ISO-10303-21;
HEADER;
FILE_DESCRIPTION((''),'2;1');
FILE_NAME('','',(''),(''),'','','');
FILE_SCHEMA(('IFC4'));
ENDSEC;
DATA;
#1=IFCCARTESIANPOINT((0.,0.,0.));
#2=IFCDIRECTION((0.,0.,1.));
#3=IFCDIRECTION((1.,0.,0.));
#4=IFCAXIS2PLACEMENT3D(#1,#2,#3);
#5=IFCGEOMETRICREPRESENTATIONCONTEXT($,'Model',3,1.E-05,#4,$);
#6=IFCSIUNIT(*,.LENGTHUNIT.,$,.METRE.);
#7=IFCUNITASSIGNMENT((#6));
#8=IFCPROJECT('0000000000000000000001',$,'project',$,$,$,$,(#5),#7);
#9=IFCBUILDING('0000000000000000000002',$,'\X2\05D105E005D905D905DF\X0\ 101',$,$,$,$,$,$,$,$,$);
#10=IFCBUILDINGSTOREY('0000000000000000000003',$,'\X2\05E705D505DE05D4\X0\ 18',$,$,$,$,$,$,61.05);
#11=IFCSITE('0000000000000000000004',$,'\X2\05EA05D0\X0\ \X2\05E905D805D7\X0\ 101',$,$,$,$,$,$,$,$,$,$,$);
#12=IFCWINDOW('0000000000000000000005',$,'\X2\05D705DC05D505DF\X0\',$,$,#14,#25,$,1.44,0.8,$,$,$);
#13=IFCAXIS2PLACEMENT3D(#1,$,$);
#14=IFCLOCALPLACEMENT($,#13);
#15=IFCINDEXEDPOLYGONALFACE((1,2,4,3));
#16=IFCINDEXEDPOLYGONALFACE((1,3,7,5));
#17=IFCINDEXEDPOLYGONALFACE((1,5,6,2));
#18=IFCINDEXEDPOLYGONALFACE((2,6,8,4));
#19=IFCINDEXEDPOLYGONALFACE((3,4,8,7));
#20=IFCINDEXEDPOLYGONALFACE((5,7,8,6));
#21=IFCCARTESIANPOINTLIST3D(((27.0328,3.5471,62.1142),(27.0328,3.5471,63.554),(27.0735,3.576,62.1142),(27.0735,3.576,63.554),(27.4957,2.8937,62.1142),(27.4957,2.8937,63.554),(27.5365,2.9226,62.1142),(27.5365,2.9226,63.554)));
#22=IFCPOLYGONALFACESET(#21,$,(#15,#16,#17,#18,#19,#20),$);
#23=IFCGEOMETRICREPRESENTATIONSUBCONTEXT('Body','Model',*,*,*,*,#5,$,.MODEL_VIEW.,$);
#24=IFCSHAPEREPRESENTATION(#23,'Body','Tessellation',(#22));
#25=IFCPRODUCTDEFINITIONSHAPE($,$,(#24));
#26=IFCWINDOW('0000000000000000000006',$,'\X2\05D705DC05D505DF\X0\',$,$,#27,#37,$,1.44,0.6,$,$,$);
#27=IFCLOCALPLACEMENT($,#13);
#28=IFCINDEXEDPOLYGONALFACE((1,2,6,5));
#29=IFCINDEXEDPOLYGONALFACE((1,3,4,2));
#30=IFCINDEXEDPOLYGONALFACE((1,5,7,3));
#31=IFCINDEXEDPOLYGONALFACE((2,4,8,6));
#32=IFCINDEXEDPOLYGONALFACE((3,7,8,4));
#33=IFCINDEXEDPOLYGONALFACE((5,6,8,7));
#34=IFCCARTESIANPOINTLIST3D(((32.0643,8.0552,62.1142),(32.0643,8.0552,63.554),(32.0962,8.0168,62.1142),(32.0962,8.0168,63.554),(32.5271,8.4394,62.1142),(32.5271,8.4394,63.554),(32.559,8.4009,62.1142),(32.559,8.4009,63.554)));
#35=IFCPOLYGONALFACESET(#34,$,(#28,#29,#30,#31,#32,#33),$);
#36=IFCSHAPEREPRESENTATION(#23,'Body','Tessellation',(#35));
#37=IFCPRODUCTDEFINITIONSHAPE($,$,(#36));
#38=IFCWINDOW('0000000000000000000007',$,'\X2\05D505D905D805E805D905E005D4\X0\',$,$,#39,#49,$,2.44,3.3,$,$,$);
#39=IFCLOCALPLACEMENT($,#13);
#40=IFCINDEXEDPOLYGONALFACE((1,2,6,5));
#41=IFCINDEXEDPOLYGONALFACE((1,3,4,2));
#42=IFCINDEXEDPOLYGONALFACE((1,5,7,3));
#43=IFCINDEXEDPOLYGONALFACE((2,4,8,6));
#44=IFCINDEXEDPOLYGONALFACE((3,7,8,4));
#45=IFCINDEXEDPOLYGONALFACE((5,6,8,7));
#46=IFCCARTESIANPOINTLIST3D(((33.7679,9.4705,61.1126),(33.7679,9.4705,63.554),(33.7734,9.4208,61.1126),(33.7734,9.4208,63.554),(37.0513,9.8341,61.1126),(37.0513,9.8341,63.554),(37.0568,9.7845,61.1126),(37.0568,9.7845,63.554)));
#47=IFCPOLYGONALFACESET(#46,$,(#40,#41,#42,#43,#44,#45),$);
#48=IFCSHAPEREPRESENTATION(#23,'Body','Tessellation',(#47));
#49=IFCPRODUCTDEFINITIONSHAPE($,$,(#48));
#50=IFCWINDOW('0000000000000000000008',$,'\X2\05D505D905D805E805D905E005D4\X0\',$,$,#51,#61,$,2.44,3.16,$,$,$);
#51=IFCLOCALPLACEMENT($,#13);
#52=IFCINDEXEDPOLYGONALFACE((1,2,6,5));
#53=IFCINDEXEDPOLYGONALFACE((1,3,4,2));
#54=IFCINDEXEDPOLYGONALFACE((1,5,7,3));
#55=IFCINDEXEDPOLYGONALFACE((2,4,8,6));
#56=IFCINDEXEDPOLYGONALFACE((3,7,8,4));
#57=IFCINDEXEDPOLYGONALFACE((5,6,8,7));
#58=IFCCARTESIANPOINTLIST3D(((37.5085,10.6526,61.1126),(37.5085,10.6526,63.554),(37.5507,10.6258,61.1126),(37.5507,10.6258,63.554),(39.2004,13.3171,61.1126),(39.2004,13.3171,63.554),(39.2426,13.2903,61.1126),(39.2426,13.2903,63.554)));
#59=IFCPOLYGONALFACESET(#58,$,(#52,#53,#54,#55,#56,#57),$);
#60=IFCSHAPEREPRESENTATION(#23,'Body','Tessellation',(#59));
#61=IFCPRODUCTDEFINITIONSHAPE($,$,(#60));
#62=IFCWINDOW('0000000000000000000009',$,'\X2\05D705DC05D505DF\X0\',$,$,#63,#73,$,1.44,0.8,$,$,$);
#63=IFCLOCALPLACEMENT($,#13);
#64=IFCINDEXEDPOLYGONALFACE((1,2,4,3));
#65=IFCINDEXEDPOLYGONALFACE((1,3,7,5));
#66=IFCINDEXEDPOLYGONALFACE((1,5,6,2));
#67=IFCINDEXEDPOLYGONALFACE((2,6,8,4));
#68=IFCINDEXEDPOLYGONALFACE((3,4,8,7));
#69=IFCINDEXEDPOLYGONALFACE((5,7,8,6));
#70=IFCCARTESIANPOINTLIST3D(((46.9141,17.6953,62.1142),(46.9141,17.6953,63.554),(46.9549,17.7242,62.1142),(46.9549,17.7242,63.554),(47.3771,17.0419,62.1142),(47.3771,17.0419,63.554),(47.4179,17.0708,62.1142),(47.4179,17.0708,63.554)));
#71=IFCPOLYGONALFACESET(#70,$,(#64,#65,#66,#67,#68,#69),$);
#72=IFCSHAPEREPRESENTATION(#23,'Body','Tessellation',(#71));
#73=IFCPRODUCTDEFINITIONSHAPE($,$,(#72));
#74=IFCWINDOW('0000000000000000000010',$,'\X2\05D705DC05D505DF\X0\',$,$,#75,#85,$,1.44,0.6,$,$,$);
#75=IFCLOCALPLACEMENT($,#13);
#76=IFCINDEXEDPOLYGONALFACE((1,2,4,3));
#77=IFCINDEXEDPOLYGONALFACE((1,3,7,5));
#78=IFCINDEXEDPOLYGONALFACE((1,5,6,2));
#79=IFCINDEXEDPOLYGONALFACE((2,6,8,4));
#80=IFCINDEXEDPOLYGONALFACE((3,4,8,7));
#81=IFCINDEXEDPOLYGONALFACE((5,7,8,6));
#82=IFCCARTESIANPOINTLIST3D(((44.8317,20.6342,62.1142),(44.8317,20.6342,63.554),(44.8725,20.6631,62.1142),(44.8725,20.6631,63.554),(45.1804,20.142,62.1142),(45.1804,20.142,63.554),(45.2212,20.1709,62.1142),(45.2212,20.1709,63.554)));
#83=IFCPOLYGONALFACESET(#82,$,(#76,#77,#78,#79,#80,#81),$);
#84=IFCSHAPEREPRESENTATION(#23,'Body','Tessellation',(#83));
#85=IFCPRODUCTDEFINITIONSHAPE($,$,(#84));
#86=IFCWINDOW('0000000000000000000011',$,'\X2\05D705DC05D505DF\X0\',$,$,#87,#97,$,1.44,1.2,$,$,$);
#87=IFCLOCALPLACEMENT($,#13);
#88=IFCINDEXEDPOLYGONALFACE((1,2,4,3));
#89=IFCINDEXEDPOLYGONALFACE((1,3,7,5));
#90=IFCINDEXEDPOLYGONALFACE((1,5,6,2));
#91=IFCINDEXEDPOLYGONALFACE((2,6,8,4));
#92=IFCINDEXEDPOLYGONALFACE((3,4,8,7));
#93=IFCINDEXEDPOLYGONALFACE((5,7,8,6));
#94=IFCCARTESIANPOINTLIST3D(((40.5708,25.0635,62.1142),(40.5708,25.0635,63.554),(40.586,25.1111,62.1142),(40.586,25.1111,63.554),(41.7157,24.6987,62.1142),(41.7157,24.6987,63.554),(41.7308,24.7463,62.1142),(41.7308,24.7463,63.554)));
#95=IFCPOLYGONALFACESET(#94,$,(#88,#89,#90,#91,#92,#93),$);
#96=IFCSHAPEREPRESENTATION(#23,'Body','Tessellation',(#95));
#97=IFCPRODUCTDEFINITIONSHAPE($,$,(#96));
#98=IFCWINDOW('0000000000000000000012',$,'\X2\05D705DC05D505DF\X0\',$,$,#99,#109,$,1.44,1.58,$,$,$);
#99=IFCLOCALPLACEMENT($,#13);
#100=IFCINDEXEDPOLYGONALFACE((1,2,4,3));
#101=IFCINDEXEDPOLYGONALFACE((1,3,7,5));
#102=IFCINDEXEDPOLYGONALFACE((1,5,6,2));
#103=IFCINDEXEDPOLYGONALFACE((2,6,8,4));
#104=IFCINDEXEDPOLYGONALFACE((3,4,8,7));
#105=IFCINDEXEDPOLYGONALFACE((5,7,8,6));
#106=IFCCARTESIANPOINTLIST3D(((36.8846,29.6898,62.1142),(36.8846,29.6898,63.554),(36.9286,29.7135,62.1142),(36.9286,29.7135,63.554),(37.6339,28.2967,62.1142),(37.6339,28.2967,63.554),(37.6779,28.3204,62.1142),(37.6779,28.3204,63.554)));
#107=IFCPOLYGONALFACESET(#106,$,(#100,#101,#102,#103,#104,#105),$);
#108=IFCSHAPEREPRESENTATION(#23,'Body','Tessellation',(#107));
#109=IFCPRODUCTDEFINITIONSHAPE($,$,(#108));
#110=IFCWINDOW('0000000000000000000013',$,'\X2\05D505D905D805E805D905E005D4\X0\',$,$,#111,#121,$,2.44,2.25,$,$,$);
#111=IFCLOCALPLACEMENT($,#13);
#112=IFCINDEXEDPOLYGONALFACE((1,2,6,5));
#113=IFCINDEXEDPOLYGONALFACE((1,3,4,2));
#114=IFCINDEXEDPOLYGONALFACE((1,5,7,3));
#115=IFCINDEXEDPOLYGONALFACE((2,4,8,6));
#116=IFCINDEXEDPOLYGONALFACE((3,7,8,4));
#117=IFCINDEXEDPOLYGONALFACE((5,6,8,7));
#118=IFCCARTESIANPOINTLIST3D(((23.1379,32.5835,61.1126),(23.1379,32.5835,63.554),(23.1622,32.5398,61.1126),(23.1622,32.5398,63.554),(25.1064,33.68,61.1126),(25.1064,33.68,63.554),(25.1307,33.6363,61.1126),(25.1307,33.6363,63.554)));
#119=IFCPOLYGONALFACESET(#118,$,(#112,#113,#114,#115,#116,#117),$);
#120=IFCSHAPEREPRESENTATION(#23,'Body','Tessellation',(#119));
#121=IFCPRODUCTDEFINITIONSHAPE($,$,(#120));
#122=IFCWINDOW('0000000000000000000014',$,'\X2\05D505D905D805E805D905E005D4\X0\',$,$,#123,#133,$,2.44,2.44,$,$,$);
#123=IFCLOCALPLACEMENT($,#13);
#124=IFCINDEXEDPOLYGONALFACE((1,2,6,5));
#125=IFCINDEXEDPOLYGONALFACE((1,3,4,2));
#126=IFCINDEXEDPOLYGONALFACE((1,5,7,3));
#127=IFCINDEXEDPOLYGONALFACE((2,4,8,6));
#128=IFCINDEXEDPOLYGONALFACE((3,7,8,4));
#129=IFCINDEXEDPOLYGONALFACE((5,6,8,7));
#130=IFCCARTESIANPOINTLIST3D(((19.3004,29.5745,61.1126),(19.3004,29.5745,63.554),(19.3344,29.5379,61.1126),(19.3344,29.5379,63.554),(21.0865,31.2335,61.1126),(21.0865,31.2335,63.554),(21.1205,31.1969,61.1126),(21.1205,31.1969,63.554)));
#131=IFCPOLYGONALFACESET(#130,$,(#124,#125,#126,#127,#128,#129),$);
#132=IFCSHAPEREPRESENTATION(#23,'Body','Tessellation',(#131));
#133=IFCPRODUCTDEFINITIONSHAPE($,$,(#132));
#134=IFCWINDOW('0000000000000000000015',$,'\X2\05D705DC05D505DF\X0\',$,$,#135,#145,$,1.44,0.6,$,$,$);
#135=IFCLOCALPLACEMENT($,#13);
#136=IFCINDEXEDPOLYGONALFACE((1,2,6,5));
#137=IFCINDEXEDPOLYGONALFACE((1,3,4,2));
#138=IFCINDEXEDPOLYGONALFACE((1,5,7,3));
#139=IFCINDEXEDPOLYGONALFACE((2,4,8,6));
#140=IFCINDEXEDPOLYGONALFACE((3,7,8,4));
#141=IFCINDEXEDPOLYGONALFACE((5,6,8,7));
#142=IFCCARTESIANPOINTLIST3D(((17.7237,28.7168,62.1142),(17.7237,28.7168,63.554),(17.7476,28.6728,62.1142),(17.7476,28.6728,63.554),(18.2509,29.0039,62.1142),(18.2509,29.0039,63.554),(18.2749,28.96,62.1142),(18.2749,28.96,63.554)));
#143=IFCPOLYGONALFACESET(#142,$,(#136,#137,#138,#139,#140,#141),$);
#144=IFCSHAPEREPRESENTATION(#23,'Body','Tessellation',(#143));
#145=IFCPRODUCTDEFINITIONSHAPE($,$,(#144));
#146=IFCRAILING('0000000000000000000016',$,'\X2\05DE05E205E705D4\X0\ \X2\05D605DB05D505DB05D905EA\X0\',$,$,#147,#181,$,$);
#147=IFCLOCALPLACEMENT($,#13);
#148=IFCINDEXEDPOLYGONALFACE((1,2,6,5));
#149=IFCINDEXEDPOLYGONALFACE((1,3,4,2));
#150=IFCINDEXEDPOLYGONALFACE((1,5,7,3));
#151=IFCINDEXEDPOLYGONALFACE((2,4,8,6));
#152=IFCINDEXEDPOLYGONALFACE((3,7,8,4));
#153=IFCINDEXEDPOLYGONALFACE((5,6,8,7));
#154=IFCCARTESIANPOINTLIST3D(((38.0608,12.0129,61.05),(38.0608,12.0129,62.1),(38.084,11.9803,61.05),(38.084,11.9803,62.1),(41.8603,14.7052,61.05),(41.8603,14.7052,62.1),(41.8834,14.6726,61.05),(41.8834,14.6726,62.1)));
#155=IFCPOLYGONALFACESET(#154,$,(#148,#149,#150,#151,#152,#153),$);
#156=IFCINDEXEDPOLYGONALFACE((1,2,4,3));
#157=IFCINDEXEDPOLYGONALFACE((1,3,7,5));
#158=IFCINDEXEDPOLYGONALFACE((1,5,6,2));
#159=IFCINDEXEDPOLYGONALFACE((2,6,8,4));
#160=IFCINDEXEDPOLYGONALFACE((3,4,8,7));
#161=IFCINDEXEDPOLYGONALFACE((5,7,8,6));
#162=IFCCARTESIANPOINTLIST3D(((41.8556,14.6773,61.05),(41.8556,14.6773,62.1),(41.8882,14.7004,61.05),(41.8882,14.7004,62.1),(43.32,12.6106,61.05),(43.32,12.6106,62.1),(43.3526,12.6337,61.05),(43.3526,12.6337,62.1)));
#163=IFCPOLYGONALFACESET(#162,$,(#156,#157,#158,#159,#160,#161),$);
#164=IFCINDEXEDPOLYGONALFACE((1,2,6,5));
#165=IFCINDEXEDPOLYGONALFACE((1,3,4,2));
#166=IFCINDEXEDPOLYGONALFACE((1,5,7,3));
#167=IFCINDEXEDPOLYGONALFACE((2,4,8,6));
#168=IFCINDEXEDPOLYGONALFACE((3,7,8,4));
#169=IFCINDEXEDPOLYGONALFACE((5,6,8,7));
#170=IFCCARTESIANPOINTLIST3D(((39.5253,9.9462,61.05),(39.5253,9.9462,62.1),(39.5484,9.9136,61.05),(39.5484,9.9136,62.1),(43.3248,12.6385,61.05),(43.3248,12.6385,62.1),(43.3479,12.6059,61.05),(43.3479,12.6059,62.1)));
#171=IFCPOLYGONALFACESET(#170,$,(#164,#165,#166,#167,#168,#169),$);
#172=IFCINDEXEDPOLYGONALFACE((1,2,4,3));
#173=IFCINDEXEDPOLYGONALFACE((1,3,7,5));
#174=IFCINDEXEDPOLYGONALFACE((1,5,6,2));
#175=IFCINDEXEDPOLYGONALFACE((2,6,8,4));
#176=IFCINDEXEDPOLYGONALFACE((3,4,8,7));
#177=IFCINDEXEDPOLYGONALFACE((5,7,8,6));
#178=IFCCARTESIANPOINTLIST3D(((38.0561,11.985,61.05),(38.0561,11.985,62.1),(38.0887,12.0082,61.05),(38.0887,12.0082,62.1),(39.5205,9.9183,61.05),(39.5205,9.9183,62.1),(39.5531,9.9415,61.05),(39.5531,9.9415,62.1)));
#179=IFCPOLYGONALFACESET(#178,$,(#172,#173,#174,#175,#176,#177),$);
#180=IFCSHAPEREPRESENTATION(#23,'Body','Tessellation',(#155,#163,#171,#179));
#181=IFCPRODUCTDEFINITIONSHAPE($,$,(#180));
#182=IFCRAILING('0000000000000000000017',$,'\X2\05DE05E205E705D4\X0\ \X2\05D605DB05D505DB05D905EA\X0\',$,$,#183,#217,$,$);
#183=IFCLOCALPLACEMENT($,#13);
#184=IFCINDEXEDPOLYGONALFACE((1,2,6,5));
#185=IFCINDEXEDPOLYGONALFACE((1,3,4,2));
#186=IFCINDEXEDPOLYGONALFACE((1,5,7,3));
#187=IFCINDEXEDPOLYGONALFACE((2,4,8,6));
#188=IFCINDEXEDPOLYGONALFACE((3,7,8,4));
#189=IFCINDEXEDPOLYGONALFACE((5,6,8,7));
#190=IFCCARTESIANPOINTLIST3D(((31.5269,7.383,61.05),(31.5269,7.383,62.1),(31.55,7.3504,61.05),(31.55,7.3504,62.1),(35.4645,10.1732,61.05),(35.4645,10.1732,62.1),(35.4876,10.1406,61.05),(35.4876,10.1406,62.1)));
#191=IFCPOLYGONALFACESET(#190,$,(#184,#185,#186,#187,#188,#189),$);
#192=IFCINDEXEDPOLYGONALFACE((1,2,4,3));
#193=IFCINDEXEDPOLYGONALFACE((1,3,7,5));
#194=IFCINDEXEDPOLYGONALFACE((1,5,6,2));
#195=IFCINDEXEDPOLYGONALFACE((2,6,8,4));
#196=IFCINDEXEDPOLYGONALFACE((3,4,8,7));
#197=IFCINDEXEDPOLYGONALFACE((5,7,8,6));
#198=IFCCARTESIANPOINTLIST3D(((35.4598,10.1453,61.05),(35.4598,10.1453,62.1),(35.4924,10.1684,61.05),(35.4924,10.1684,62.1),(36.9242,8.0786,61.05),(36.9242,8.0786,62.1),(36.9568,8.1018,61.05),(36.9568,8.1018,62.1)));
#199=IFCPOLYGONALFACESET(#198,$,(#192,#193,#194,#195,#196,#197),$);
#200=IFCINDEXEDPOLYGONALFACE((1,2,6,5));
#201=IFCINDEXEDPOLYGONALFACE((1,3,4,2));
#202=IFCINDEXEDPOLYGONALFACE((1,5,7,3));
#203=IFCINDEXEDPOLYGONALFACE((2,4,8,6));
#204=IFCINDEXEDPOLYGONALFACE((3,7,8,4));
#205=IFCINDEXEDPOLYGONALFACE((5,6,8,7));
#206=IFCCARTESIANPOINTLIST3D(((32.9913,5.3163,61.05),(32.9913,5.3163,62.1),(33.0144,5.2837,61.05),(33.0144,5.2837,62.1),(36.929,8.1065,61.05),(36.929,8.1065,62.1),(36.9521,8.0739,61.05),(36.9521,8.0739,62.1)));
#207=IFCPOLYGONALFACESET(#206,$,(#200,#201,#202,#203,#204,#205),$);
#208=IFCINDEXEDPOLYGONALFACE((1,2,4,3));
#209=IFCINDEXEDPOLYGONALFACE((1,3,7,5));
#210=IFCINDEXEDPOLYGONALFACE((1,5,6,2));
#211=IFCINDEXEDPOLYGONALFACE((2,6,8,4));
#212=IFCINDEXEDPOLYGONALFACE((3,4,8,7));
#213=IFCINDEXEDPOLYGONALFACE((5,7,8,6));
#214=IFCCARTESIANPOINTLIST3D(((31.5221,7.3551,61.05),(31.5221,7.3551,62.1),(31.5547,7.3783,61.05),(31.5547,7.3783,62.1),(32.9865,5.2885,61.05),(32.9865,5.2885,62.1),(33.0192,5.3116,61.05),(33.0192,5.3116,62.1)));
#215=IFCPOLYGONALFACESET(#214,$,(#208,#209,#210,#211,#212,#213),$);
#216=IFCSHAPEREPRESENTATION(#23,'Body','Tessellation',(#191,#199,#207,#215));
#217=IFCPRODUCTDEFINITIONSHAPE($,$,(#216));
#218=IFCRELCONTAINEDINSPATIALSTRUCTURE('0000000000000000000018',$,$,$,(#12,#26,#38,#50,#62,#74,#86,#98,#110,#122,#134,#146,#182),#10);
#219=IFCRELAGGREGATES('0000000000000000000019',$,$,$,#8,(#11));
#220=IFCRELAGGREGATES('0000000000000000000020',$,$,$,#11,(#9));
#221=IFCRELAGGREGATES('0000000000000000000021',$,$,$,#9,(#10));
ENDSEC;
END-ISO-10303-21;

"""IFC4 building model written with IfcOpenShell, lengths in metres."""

from ifc_helpers import new_model, si_unit, frame, origin_with_axes, context, subcontext, project, spatial, polyline, outline, extrude, element, save


model = new_model("IFC4")

# Units and contexts
model_context = context("Model", 3, precision=1e-05, world=origin_with_axes())
body_context = subcontext(model_context, "Body", "Model", "MODEL_VIEW")
ifc_project = project(units=[si_unit("LENGTHUNIT", "METRE")], contexts=[model_context])

# Site, building, storey
site = spatial("IfcSite", under=ifc_project, Name="תא שטח 101")
building = spatial("IfcBuilding", under=site, Name="בניין 101")
storey = spatial("IfcBuildingStorey", under=building, Name="קומה 18", Elevation=61.05)

# Windows
element("IfcWindow", 1, inside=storey, Name="חלון", OverallHeight=1.44, OverallWidth=0.8, context=body_context, shape_type="SweptSolid", body=[
    extrude(outline(polyline([(27.0328, 3.5471), (27.4957, 2.8937), (27.5365, 2.9226), (27.0735, 3.576), (27.0328, 3.5471)])), frame((0.0, 0.0, 62.1142)), (0.0, 0.0, 1.0), 1.4398),
])
element("IfcWindow", 2, inside=storey, Name="חלון", OverallHeight=1.44, OverallWidth=0.6, context=body_context, shape_type="SweptSolid", body=[
    extrude(outline(polyline([(32.0962, 8.0168), (32.559, 8.4009), (32.5271, 8.4394), (32.0643, 8.0552), (32.0962, 8.0168)])), frame((0.0, 0.0, 62.1142)), (0.0, 0.0, 1.0), 1.4398),
])
element("IfcWindow", 3, inside=storey, Name="ויטרינה", OverallHeight=2.44, OverallWidth=3.3, context=body_context, shape_type="SweptSolid", body=[
    extrude(outline(polyline([(33.7734, 9.4208), (37.0568, 9.7845), (37.0513, 9.8341), (33.7679, 9.4705), (33.7734, 9.4208)])), frame((0.0, 0.0, 61.1126)), (0.0, 0.0, 1.0), 2.4414),
])
element("IfcWindow", 4, inside=storey, Name="ויטרינה", OverallHeight=2.44, OverallWidth=3.16, context=body_context, shape_type="SweptSolid", body=[
    extrude(outline(polyline([(37.5507, 10.6258), (39.2426, 13.2903), (39.2004, 13.3171), (37.5085, 10.6526), (37.5507, 10.6258)])), frame((0.0, 0.0, 61.1126)), (0.0, 0.0, 1.0), 2.4414),
])
element("IfcWindow", 5, inside=storey, Name="חלון", OverallHeight=1.44, OverallWidth=0.8, context=body_context, shape_type="SweptSolid", body=[
    extrude(outline(polyline([(47.4179, 17.0708), (46.9549, 17.7242), (46.9141, 17.6953), (47.3771, 17.0419), (47.4179, 17.0708)])), frame((0.0, 0.0, 62.1142)), (0.0, 0.0, 1.0), 1.4398),
])
element("IfcWindow", 6, inside=storey, Name="חלון", OverallHeight=1.44, OverallWidth=0.6, context=body_context, shape_type="SweptSolid", body=[
    extrude(outline(polyline([(45.2212, 20.1709), (44.8725, 20.6631), (44.8317, 20.6342), (45.1804, 20.142), (45.2212, 20.1709)])), frame((0.0, 0.0, 62.1142)), (0.0, 0.0, 1.0), 1.4398),
])
element("IfcWindow", 7, inside=storey, Name="חלון", OverallHeight=1.44, OverallWidth=1.2, context=body_context, shape_type="SweptSolid", body=[
    extrude(outline(polyline([(41.7308, 24.7463), (40.586, 25.1111), (40.5708, 25.0635), (41.7157, 24.6987), (41.7308, 24.7463)])), frame((0.0, 0.0, 62.1142)), (0.0, 0.0, 1.0), 1.4398),
])
element("IfcWindow", 8, inside=storey, Name="חלון", OverallHeight=1.44, OverallWidth=1.58, context=body_context, shape_type="SweptSolid", body=[
    extrude(outline(polyline([(37.6779, 28.3204), (36.9286, 29.7135), (36.8846, 29.6898), (37.6339, 28.2967), (37.6779, 28.3204)])), frame((0.0, 0.0, 62.1142)), (0.0, 0.0, 1.0), 1.4398),
])
element("IfcWindow", 9, inside=storey, Name="ויטרינה", OverallHeight=2.44, OverallWidth=2.25, context=body_context, shape_type="SweptSolid", body=[
    extrude(outline(polyline([(25.1064, 33.68), (23.1379, 32.5835), (23.1622, 32.5398), (25.1307, 33.6363), (25.1064, 33.68)])), frame((0.0, 0.0, 61.1126)), (0.0, 0.0, 1.0), 2.4414),
])
element("IfcWindow", 10, inside=storey, Name="ויטרינה", OverallHeight=2.44, OverallWidth=2.44, context=body_context, shape_type="SweptSolid", body=[
    extrude(outline(polyline([(21.0865, 31.2335), (19.3004, 29.5745), (19.3344, 29.5379), (21.1205, 31.1969), (21.0865, 31.2335)])), frame((0.0, 0.0, 61.1126)), (0.0, 0.0, 1.0), 2.4414),
])
element("IfcWindow", 11, inside=storey, Name="חלון", OverallHeight=1.44, OverallWidth=0.6, context=body_context, shape_type="SweptSolid", body=[
    extrude(outline(polyline([(18.2509, 29.0039), (17.7237, 28.7168), (17.7476, 28.6728), (18.2749, 28.96), (18.2509, 29.0039)])), frame((0.0, 0.0, 62.1142)), (0.0, 0.0, 1.0), 1.4398),
])

# Railings
element("IfcRailing", 12, inside=storey, Name="מעקה זכוכית", context=body_context, shape_type="SweptSolid", body=[
    extrude(outline(polyline([(38.084, 11.9803), (41.8834, 14.6726), (41.8603, 14.7052), (38.0608, 12.0129), (38.084, 11.9803)])), frame((0.0, 0.0, 61.05)), (0.0, 0.0, 1.0), 1.05),
    extrude(outline(polyline([(41.8556, 14.6773), (43.32, 12.6106), (43.3526, 12.6337), (41.8882, 14.7004), (41.8556, 14.6773)])), frame((0.0, 0.0, 61.05)), (0.0, 0.0, 1.0), 1.05),
    extrude(outline(polyline([(43.3248, 12.6385), (39.5253, 9.9462), (39.5484, 9.9136), (43.3479, 12.6059), (43.3248, 12.6385)])), frame((0.0, 0.0, 61.05)), (0.0, 0.0, 1.0), 1.05),
    extrude(outline(polyline([(39.5531, 9.9415), (38.0887, 12.0082), (38.0561, 11.985), (39.5205, 9.9183), (39.5531, 9.9415)])), frame((0.0, 0.0, 61.05)), (0.0, 0.0, 1.0), 1.05),
])
element("IfcRailing", 13, inside=storey, Name="מעקה זכוכית", context=body_context, shape_type="SweptSolid", body=[
    extrude(outline(polyline([(31.55, 7.3504), (35.4876, 10.1406), (35.4645, 10.1732), (31.5269, 7.383), (31.55, 7.3504)])), frame((0.0, 0.0, 61.05)), (0.0, 0.0, 1.0), 1.05),
    extrude(outline(polyline([(35.4598, 10.1453), (36.9242, 8.0786), (36.9568, 8.1018), (35.4924, 10.1684), (35.4598, 10.1453)])), frame((0.0, 0.0, 61.05)), (0.0, 0.0, 1.0), 1.05),
    extrude(outline(polyline([(36.929, 8.1065), (32.9913, 5.3163), (33.0144, 5.2837), (36.9521, 8.0739), (36.929, 8.1065)])), frame((0.0, 0.0, 61.05)), (0.0, 0.0, 1.0), 1.05),
    extrude(outline(polyline([(33.0192, 5.3116), (31.5547, 7.3783), (31.5221, 7.3551), (32.9865, 5.2885), (33.0192, 5.3116)])), frame((0.0, 0.0, 61.05)), (0.0, 0.0, 1.0), 1.05),
])

save(model, "model.ifc")
